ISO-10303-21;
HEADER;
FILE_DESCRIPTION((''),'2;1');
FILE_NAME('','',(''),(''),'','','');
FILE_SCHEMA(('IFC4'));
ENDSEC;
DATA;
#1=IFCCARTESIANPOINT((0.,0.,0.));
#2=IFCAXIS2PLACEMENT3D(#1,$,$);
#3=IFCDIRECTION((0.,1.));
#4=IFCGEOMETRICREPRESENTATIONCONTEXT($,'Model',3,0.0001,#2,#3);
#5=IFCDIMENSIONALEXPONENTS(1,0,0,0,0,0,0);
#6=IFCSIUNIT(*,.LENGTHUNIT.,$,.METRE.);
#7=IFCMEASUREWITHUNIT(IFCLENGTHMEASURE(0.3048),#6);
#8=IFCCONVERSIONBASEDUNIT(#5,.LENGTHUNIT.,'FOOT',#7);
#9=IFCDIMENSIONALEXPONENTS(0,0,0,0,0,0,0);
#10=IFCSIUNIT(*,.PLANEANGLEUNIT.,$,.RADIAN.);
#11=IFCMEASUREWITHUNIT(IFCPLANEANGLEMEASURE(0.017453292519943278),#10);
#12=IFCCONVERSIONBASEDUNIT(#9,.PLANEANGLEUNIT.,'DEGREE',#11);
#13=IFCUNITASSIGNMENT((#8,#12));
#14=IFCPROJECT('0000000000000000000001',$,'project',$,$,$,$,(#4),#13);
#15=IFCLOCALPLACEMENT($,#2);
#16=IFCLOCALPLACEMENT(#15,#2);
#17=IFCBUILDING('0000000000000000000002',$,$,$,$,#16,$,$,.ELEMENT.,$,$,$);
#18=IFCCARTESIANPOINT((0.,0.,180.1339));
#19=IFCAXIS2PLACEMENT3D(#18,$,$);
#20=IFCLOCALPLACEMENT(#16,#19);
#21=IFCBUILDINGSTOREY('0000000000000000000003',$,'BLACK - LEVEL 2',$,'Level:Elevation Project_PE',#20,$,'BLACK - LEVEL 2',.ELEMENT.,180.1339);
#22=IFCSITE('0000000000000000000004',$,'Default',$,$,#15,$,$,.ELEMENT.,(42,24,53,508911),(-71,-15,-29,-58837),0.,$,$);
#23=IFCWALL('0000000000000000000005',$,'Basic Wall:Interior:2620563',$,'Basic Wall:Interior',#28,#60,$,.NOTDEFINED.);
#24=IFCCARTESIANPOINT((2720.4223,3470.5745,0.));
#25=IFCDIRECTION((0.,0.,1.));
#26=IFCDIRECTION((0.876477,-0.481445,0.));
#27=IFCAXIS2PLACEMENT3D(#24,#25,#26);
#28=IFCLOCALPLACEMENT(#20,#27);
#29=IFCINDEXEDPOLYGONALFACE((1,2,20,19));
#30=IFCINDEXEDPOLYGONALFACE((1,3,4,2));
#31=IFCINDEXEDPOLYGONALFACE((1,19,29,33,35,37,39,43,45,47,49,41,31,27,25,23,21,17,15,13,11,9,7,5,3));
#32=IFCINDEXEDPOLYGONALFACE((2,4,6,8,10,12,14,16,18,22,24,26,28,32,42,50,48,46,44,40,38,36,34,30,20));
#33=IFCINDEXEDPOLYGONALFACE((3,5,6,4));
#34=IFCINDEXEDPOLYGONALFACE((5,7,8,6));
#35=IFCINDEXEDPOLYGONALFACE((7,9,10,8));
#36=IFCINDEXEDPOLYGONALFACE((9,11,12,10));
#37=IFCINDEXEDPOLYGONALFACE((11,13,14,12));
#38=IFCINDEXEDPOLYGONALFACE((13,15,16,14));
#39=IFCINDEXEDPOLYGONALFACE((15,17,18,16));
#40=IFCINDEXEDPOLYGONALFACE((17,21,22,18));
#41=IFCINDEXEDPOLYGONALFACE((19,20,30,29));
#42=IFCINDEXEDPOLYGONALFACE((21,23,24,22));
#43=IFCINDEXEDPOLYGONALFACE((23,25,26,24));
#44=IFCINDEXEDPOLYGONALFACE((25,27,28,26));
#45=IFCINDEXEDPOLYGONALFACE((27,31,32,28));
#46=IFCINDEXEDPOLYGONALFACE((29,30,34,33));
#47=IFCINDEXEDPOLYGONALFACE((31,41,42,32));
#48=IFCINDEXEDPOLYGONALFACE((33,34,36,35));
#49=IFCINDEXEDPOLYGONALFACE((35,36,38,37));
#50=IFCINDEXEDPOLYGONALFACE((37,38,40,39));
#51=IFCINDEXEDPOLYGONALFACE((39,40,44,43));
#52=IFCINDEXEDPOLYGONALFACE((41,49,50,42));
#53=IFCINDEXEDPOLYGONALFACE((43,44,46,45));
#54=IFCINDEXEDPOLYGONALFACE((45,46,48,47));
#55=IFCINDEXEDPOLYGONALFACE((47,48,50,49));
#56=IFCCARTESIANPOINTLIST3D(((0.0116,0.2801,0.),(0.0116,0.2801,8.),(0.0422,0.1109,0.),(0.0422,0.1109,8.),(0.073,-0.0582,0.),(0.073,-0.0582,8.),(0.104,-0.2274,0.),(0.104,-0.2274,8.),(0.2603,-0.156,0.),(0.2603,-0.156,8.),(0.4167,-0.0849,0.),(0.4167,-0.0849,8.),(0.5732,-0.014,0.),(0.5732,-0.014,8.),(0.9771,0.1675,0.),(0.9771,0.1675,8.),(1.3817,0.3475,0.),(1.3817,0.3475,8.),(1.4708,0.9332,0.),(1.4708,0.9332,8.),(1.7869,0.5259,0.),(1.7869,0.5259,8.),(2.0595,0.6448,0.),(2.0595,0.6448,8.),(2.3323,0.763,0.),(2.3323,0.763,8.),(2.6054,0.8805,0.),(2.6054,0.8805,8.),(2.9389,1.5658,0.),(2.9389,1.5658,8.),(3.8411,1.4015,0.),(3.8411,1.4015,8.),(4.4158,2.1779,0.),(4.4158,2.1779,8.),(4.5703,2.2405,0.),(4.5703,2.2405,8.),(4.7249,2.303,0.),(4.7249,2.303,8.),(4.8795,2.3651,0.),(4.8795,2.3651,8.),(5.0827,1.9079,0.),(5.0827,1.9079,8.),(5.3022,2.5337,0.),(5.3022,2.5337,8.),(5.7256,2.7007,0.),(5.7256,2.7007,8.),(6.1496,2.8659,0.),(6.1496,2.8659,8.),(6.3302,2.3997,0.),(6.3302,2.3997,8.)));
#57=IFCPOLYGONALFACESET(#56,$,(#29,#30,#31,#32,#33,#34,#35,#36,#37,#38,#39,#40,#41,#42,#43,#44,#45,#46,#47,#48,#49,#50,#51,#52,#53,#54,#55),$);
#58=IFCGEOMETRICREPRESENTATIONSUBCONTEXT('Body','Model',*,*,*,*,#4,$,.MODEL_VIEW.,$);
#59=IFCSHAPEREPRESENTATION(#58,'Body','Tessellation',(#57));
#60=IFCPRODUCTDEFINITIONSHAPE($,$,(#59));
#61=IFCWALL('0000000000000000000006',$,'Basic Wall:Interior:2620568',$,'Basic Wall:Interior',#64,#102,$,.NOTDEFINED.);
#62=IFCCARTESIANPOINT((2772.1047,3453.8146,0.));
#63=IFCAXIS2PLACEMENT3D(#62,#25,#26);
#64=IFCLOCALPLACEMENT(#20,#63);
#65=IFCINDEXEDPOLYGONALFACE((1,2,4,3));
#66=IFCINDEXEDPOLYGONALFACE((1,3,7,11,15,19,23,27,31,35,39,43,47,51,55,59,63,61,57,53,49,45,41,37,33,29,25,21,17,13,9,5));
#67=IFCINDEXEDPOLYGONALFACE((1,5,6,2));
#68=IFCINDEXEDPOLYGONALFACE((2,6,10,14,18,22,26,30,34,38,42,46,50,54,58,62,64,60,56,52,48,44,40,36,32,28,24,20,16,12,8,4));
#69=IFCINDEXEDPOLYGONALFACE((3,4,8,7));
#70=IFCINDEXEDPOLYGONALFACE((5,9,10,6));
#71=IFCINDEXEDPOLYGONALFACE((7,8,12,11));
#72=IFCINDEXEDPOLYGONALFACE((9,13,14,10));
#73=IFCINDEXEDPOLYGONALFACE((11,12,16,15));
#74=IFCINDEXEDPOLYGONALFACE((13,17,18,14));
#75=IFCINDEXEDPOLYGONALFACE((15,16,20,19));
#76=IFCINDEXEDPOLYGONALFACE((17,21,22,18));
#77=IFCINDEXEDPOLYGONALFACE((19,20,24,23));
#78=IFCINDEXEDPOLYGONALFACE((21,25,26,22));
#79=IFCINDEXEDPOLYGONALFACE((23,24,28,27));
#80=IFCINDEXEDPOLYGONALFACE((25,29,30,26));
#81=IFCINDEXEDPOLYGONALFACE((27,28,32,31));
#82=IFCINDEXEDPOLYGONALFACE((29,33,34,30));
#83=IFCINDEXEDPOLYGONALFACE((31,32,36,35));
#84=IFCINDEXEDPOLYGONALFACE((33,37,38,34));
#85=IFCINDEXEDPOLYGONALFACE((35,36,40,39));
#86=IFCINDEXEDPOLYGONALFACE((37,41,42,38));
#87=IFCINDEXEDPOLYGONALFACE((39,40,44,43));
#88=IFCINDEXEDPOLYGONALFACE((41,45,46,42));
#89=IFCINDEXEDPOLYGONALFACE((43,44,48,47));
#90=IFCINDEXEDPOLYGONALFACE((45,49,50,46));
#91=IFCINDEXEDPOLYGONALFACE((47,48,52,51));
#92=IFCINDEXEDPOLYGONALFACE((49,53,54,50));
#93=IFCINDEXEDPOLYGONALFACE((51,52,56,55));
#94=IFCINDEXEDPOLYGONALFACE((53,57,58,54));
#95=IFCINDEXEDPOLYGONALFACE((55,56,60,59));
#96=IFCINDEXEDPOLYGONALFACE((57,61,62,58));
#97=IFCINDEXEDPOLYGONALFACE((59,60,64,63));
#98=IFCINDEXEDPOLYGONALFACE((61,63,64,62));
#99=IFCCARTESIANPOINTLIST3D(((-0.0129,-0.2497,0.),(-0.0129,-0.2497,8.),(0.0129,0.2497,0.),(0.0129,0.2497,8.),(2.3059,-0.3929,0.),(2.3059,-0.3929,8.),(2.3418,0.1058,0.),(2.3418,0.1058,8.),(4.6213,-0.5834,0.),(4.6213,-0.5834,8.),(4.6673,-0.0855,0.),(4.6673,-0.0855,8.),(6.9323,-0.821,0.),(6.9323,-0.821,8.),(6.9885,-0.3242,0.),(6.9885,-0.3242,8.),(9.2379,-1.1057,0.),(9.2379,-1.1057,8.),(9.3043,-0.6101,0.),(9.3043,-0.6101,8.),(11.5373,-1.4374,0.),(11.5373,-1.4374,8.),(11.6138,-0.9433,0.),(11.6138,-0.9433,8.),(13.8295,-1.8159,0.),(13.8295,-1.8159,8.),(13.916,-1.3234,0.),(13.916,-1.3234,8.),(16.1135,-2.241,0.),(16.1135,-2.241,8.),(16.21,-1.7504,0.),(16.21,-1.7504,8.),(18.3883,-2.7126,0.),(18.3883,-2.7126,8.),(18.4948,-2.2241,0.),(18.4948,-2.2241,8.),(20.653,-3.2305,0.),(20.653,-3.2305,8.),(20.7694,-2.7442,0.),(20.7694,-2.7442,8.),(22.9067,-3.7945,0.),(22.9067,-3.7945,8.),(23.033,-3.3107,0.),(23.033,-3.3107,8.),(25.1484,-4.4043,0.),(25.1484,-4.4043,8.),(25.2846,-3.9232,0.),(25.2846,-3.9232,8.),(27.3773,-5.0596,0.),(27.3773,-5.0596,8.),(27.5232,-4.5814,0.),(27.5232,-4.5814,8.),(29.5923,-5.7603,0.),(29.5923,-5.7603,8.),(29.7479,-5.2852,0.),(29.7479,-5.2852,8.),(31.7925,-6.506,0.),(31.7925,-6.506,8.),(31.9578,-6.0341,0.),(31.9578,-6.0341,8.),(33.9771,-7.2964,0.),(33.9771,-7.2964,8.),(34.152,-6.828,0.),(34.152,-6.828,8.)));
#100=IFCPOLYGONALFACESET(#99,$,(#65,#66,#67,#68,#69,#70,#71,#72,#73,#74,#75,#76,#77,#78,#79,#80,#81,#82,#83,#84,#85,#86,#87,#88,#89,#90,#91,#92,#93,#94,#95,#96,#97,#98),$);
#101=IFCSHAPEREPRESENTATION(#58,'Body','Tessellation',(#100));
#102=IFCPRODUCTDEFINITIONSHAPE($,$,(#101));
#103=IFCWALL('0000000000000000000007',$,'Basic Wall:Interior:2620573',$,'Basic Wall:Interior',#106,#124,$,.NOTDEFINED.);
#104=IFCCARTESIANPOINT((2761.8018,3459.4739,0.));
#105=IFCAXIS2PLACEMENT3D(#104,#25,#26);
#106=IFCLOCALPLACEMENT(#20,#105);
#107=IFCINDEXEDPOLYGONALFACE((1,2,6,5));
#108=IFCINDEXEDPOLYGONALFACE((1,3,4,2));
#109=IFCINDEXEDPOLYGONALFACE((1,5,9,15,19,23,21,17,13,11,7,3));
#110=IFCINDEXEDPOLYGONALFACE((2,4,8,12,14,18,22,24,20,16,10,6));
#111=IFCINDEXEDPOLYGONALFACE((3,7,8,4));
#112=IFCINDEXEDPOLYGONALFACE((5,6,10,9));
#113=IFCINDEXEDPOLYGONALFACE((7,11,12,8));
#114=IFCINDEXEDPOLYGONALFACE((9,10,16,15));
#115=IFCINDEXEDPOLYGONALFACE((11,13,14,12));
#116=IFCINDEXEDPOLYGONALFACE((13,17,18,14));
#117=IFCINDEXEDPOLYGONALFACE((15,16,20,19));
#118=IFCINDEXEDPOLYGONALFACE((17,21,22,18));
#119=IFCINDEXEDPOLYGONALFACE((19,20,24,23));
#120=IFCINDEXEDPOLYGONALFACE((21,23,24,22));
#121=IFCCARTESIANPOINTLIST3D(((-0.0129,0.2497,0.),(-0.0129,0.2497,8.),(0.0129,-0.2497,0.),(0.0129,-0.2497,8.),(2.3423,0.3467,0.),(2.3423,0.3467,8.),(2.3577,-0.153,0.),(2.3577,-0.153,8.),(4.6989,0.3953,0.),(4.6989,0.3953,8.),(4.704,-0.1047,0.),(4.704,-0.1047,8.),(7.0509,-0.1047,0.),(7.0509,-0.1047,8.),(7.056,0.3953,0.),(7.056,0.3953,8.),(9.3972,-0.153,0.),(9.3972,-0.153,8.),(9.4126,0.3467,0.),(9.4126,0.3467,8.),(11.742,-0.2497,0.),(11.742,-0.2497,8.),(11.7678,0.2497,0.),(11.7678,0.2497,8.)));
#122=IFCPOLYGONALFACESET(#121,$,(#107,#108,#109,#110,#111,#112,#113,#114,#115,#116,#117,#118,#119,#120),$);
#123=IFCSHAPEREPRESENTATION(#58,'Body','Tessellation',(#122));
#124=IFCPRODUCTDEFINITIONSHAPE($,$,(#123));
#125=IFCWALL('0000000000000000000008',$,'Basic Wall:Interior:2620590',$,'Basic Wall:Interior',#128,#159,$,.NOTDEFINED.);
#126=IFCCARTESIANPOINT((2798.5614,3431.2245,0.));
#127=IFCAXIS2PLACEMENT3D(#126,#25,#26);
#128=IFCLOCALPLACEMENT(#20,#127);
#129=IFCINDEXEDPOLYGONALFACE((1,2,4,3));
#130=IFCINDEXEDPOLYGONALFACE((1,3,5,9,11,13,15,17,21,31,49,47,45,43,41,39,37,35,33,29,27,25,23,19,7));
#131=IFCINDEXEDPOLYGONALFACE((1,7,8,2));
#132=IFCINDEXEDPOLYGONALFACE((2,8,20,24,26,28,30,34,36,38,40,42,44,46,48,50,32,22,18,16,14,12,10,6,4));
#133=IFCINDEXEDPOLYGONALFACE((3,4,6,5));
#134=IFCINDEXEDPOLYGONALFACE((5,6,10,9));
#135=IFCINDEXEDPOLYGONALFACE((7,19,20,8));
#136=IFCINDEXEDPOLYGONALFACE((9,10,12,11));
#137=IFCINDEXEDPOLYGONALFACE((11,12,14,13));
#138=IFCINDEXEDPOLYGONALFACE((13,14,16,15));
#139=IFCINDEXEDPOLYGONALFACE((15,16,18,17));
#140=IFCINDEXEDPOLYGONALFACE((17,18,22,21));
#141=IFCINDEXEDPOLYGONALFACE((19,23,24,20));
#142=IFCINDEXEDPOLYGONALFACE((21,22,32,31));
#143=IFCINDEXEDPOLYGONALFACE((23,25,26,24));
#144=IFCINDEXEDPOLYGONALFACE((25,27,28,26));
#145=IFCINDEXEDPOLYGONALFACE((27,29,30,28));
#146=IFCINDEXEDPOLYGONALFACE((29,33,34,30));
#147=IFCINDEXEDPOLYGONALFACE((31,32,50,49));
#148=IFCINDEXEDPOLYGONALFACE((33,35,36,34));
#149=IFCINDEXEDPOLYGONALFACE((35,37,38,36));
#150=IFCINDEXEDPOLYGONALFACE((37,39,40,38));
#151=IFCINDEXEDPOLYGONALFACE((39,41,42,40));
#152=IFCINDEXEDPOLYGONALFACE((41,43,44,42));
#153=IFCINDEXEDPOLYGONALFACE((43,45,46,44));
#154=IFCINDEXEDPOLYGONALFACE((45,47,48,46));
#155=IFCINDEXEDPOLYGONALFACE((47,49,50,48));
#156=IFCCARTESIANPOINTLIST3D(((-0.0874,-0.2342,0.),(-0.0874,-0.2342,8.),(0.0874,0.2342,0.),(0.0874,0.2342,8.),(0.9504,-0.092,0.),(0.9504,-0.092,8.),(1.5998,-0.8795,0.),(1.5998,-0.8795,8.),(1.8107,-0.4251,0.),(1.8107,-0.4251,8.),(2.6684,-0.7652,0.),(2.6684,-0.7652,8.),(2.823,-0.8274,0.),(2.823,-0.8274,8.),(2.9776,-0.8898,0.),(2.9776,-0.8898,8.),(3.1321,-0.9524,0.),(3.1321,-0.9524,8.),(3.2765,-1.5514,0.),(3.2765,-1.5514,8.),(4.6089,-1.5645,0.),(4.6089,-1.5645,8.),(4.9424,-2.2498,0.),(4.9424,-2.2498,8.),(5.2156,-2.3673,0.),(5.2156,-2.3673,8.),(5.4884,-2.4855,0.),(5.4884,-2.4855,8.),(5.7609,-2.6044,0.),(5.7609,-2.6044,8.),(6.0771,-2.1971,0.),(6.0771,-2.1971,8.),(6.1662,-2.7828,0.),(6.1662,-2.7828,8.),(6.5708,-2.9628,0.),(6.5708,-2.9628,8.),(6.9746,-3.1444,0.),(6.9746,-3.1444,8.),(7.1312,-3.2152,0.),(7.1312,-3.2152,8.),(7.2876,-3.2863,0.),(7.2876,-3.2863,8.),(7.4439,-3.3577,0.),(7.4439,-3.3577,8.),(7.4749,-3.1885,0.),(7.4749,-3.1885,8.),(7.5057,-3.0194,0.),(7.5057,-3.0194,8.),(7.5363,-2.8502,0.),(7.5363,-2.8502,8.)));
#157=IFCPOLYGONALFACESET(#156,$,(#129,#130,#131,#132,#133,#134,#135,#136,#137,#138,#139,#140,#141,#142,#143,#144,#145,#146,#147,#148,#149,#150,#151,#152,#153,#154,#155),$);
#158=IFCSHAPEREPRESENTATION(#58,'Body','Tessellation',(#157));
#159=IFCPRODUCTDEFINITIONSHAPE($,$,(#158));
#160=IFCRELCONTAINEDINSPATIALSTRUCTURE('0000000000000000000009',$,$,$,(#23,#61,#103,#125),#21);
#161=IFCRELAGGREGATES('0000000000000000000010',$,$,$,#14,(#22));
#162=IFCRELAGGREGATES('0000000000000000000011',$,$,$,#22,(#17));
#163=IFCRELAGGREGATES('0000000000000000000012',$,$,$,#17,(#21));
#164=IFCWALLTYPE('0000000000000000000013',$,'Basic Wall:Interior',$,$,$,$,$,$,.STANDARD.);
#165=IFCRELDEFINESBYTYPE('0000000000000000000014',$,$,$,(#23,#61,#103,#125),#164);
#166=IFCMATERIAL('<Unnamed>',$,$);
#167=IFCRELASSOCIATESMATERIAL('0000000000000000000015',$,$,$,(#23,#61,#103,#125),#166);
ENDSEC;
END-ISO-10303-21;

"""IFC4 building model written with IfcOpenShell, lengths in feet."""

from ifc_helpers import new_model, entity, si_unit, converted_unit, direction, frame, origin, place, context, subcontext, project, spatial, line, arc, indexed_curve, outline, extrude, material, type_object, element, save


model = new_model("IFC4")

# Units and contexts
model_context = context("Model", 3, precision=0.0001, world=origin(), true_north=direction((0.0, 1.0)))
body_context = subcontext(model_context, "Body", "Model", "MODEL_VIEW")
ifc_project = project(units=[converted_unit("LENGTHUNIT", "FOOT", entity("IfcLengthMeasure", 0.3048), si_unit("LENGTHUNIT", "METRE"), dimensions=[1, 0, 0, 0, 0, 0, 0]), converted_unit("PLANEANGLEUNIT", "DEGREE", entity("IfcPlaneAngleMeasure", 0.017453292519943278), si_unit("PLANEANGLEUNIT", "RADIAN"), dimensions=[0, 0, 0, 0, 0, 0, 0])], contexts=[model_context])

# Site, building, storey
site_placement = place(None, origin())
site = spatial("IfcSite", under=ifc_project, at=site_placement, Name="Default", CompositionType="ELEMENT", RefLatitude=(42, 24, 53, 508911), RefLongitude=(-71, -15, -29, -58837), RefElevation=0.0)
building_placement = place(site_placement, origin())
building = spatial("IfcBuilding", under=site, at=building_placement, CompositionType="ELEMENT")
storey_placement = place(building_placement, frame((0.0, 0.0, 180.1339)))
storey = spatial("IfcBuildingStorey", under=building, at=storey_placement, Name="BLACK - LEVEL 2", ObjectType="Level:Elevation Project_PE", LongName="BLACK - LEVEL 2", CompositionType="ELEMENT", Elevation=180.1339)

# Walls
ifc_material = material(Name="<Unnamed>")
wall_type = type_object("IfcWallType", Name="Basic Wall:Interior", PredefinedType="STANDARD")
wall_1_placement = place(storey_placement, frame((2720.4223, 3470.5745, 0.0), z_axis=(0.0, 0.0, 1.0), x_axis=(0.876477, -0.481445, 0.0)))
element("IfcWall", 1, at=wall_1_placement, inside=storey, type_object=wall_type, material=ifc_material, Name="Basic Wall:Interior:2620563", ObjectType="Basic Wall:Interior", PredefinedType="NOTDEFINED", context=body_context, shape_type="SweptSolid", body=[
    extrude(outline(indexed_curve([(6.1496, 2.8659), (5.5138, 2.6174), (4.8795, 2.3651), (4.6476, 2.2718), (4.4158, 2.1779), (2.2037, 1.2521), (0.0116, 0.2801), (0.0576, 0.0264), (0.104, -0.2274), (0.3385, -0.1204), (0.5732, -0.014), (1.1793, 0.2577), (1.7869, 0.5259), (2.1958, 0.704), (2.6054, 0.8805), (4.4611, 1.6565), (6.3302, 2.3997)], segments=[arc(1, 2, 3), arc(3, 4, 5), arc(5, 6, 7), arc(7, 8, 9), arc(9, 10, 11), arc(11, 12, 13), arc(13, 14, 15), arc(15, 16, 17), line(17, 1)], self_intersect=False)), origin(), (0.0, 0.0, 1.0), 8.0),
])
wall_2_placement = place(storey_placement, frame((2772.1047, 3453.8146, 0.0), z_axis=(0.0, 0.0, 1.0), x_axis=(0.876477, -0.481445, 0.0)))
element("IfcWall", 2, at=wall_2_placement, inside=storey, type_object=wall_type, material=ifc_material, Name="Basic Wall:Interior:2620568", ObjectType="Basic Wall:Interior", PredefinedType="NOTDEFINED", context=body_context, shape_type="SweptSolid", body=[
    extrude(outline(indexed_curve([(34.152, -6.828), (17.3536, -1.9814), (0.0129, 0.2497), (-0.0129, -0.2497), (17.2521, -2.471), (33.9771, -7.2964)], segments=[arc(1, 2, 3), line(3, 4), arc(4, 5, 6), line(6, 1)], self_intersect=False)), origin(), (0.0, 0.0, 1.0), 8.0),
])
wall_3_placement = place(storey_placement, frame((2761.8018, 3459.4739, 0.0), z_axis=(0.0, 0.0, 1.0), x_axis=(0.876477, -0.481445, 0.0)))
element("IfcWall", 3, at=wall_3_placement, inside=storey, type_object=wall_type, material=ifc_material, Name="Basic Wall:Interior:2620573", ObjectType="Basic Wall:Interior", PredefinedType="NOTDEFINED", context=body_context, shape_type="SweptSolid", body=[
    extrude(outline(indexed_curve([(11.7678, 0.2497), (5.8775, 0.4014), (-0.0129, 0.2497), (0.0129, -0.2497), (5.8775, -0.0986), (11.742, -0.2497)], segments=[arc(1, 2, 3), line(3, 4), arc(4, 5, 6), line(6, 1)], self_intersect=False)), origin(), (0.0, 0.0, 1.0), 8.0),
])
wall_4_placement = place(storey_placement, frame((2798.5614, 3431.2245, 0.0), z_axis=(0.0, 0.0, 1.0), x_axis=(0.876477, -0.481445, 0.0)))
element("IfcWall", 4, at=wall_4_placement, inside=storey, type_object=wall_type, material=ifc_material, Name="Basic Wall:Interior:2620590", ObjectType="Basic Wall:Interior", PredefinedType="NOTDEFINED", context=body_context, shape_type="SweptSolid", body=[
    extrude(outline(indexed_curve([(7.5363, -2.8502), (5.3441, -1.8782), (3.1321, -0.9524), (2.9003, -0.8585), (2.6684, -0.7652), (1.3809, -0.2577), (0.0874, 0.2342), (-0.0874, -0.2342), (2.4395, -1.2121), (4.9424, -2.2498), (5.352, -2.4263), (5.7609, -2.6044), (6.3686, -2.8726), (6.9746, -3.1444), (7.2094, -3.2507), (7.4439, -3.3577), (7.4903, -3.104)], segments=[arc(1, 2, 3), arc(3, 4, 5), arc(5, 6, 7), line(7, 8), arc(8, 9, 10), arc(10, 11, 12), arc(12, 13, 14), arc(14, 15, 16), arc(16, 17, 1)], self_intersect=False)), origin(), (0.0, 0.0, 1.0), 8.0),
])

save(model, "model.ifc")
